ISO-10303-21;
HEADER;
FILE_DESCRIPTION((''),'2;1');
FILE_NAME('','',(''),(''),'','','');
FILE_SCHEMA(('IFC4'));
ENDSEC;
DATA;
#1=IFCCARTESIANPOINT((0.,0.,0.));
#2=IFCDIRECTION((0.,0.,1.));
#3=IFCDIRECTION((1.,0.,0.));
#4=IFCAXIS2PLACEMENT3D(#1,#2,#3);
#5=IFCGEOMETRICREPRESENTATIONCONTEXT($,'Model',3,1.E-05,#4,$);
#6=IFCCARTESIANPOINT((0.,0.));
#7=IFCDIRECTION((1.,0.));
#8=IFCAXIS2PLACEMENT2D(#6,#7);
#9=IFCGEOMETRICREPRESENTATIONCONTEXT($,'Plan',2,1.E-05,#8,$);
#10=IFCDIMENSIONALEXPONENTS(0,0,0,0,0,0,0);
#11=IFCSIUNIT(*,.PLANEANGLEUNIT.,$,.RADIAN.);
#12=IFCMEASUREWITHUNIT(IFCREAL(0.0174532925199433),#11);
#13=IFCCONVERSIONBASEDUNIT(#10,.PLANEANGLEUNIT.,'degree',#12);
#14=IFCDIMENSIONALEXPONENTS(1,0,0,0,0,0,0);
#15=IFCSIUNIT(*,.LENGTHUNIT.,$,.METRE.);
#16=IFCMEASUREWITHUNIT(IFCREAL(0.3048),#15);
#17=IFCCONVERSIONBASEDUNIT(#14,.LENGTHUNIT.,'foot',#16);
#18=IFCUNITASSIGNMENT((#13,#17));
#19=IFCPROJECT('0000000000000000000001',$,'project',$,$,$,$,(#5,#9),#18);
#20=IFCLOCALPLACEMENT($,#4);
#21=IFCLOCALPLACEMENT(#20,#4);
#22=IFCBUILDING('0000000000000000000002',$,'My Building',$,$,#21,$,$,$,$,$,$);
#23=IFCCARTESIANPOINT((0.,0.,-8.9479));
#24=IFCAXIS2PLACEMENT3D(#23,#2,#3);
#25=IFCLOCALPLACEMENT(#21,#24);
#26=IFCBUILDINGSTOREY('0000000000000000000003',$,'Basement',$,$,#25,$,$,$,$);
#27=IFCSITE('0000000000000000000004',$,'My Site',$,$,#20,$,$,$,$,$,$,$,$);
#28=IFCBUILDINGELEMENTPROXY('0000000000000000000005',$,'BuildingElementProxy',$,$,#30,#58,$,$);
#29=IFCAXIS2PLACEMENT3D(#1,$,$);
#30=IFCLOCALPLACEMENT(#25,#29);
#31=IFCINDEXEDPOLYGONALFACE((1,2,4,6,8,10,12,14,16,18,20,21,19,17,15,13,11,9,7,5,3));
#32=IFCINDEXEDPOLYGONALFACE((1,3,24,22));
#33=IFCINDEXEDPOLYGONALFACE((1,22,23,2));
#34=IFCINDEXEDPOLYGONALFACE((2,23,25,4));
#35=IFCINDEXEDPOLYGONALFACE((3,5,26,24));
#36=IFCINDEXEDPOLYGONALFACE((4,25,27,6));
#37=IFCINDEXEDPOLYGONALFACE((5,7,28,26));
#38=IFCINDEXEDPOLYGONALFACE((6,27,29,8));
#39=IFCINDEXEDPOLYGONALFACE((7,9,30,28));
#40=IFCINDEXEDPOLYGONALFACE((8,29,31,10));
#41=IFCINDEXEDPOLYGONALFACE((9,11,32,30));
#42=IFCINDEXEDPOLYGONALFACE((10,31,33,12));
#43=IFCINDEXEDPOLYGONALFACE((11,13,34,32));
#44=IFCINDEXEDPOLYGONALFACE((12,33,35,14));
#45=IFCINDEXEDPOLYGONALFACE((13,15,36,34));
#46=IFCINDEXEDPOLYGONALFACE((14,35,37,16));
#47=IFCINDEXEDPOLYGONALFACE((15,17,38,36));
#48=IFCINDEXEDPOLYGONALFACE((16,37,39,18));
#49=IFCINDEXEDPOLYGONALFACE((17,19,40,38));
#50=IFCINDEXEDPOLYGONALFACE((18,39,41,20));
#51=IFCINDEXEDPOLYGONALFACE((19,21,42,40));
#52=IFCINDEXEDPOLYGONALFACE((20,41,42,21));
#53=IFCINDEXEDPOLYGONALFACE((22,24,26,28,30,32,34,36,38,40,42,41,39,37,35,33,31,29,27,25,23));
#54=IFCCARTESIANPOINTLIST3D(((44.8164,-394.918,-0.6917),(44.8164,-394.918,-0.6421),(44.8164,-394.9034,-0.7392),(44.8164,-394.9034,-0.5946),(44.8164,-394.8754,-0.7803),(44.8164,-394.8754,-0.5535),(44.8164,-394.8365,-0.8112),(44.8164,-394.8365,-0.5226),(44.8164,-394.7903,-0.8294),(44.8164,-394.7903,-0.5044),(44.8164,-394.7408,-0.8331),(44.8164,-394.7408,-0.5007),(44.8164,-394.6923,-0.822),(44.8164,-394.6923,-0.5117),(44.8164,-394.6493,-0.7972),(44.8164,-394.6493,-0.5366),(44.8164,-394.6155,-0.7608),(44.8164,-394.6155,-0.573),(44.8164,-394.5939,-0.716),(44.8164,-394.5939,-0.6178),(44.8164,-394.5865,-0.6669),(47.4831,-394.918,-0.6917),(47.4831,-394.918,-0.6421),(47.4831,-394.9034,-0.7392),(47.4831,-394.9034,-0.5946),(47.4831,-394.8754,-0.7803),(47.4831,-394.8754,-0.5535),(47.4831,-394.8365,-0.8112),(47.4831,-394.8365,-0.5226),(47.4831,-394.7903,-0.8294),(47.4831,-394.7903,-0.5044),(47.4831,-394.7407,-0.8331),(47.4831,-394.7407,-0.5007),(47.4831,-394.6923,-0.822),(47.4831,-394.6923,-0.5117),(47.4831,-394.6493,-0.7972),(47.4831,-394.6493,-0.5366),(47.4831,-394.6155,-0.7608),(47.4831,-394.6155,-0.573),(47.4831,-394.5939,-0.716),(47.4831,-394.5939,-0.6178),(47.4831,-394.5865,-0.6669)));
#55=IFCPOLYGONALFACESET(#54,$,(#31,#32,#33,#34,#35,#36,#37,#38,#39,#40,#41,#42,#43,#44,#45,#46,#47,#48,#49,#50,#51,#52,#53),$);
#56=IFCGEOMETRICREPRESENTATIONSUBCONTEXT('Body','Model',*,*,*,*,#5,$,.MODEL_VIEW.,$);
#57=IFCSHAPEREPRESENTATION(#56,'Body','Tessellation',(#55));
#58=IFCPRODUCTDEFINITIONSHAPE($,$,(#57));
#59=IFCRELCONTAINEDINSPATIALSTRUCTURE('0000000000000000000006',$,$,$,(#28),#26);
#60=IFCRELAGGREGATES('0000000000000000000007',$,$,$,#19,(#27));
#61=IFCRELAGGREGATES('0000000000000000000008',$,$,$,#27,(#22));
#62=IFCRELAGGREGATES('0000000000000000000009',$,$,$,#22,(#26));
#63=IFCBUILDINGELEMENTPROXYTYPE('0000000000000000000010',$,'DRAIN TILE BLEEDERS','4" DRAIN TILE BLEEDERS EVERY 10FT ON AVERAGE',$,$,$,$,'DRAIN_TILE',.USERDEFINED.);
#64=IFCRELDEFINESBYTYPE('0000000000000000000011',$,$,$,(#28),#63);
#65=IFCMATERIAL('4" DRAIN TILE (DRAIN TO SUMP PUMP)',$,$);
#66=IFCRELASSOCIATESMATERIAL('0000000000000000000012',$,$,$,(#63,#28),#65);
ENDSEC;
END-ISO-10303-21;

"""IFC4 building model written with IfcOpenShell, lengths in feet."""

from ifc_helpers import new_model, entity, si_unit, converted_unit, frame, origin_with_axes, origin_2d_with_axis, place, context, subcontext, project, spatial, circle, extrude, material, material_profile, profile_set, profile_usage, type_object, element, save


model = new_model("IFC4")

# Units and contexts
model_context = context("Model", 3, precision=1e-05, world=origin_with_axes())
plan_context = context("Plan", 2, precision=1e-05, world=origin_2d_with_axis())
body_context = subcontext(model_context, "Body", "Model", "MODEL_VIEW")
ifc_project = project(units=[converted_unit("PLANEANGLEUNIT", "degree", entity("IfcReal", 0.0174532925199433), si_unit("PLANEANGLEUNIT", "RADIAN"), dimensions=[0, 0, 0, 0, 0, 0, 0]), converted_unit("LENGTHUNIT", "foot", entity("IfcReal", 0.3048), si_unit("LENGTHUNIT", "METRE"), dimensions=[1, 0, 0, 0, 0, 0, 0])], contexts=[model_context, plan_context])

# Site, building, storey
site_placement = place(None, origin_with_axes())
site = spatial("IfcSite", under=ifc_project, at=site_placement, Name="My Site")
building_placement = place(site_placement, origin_with_axes())
building = spatial("IfcBuilding", under=site, at=building_placement, Name="My Building")
storey_placement = place(building_placement, frame((0.0, 0.0, -8.9479), z_axis=(0.0, 0.0, 1.0), x_axis=(1.0, 0.0, 0.0)))
storey = spatial("IfcBuildingStorey", under=building, at=storey_placement, Name="Basement")

# Building element proxy
ifc_material_1 = material(Name="4\" DRAIN TILE (DRAIN TO SUMP PUMP)")
ifc_material_profile_1 = material_profile(ifc_material_1, circle(Radius=0.1667, kind="CURVE"))
ifc_profile_set_1 = profile_set([ifc_material_profile_1])
building_element_proxy_type_1 = type_object("IfcBuildingElementProxyType", Name="DRAIN TILE BLEEDERS", Description="4\" DRAIN TILE BLEEDERS EVERY 10FT ON AVERAGE", ElementType="DRAIN_TILE", PredefinedType="USERDEFINED", material=ifc_profile_set_1)
ifc_profile_usage_1 = profile_usage(ifc_profile_set_1)
proxy_1_placement = place(storey_placement, frame((44.8164, -394.7532, -0.6669), z_axis=(1.0, 0.000002, 0.0), x_axis=(-0.000002, 1.0, 0.0)))
element("IfcBuildingElementProxy", 1, at=proxy_1_placement, inside=storey, type_object=building_element_proxy_type_1, material=ifc_profile_usage_1, Name="BuildingElementProxy", context=body_context, shape_type="SweptSolid", body=[
    extrude(circle(Radius=0.1667, kind="CURVE"), origin_with_axes(), (0.0, 0.0, 1.0), 2.6667),
])

save(model, "model.ifc")
